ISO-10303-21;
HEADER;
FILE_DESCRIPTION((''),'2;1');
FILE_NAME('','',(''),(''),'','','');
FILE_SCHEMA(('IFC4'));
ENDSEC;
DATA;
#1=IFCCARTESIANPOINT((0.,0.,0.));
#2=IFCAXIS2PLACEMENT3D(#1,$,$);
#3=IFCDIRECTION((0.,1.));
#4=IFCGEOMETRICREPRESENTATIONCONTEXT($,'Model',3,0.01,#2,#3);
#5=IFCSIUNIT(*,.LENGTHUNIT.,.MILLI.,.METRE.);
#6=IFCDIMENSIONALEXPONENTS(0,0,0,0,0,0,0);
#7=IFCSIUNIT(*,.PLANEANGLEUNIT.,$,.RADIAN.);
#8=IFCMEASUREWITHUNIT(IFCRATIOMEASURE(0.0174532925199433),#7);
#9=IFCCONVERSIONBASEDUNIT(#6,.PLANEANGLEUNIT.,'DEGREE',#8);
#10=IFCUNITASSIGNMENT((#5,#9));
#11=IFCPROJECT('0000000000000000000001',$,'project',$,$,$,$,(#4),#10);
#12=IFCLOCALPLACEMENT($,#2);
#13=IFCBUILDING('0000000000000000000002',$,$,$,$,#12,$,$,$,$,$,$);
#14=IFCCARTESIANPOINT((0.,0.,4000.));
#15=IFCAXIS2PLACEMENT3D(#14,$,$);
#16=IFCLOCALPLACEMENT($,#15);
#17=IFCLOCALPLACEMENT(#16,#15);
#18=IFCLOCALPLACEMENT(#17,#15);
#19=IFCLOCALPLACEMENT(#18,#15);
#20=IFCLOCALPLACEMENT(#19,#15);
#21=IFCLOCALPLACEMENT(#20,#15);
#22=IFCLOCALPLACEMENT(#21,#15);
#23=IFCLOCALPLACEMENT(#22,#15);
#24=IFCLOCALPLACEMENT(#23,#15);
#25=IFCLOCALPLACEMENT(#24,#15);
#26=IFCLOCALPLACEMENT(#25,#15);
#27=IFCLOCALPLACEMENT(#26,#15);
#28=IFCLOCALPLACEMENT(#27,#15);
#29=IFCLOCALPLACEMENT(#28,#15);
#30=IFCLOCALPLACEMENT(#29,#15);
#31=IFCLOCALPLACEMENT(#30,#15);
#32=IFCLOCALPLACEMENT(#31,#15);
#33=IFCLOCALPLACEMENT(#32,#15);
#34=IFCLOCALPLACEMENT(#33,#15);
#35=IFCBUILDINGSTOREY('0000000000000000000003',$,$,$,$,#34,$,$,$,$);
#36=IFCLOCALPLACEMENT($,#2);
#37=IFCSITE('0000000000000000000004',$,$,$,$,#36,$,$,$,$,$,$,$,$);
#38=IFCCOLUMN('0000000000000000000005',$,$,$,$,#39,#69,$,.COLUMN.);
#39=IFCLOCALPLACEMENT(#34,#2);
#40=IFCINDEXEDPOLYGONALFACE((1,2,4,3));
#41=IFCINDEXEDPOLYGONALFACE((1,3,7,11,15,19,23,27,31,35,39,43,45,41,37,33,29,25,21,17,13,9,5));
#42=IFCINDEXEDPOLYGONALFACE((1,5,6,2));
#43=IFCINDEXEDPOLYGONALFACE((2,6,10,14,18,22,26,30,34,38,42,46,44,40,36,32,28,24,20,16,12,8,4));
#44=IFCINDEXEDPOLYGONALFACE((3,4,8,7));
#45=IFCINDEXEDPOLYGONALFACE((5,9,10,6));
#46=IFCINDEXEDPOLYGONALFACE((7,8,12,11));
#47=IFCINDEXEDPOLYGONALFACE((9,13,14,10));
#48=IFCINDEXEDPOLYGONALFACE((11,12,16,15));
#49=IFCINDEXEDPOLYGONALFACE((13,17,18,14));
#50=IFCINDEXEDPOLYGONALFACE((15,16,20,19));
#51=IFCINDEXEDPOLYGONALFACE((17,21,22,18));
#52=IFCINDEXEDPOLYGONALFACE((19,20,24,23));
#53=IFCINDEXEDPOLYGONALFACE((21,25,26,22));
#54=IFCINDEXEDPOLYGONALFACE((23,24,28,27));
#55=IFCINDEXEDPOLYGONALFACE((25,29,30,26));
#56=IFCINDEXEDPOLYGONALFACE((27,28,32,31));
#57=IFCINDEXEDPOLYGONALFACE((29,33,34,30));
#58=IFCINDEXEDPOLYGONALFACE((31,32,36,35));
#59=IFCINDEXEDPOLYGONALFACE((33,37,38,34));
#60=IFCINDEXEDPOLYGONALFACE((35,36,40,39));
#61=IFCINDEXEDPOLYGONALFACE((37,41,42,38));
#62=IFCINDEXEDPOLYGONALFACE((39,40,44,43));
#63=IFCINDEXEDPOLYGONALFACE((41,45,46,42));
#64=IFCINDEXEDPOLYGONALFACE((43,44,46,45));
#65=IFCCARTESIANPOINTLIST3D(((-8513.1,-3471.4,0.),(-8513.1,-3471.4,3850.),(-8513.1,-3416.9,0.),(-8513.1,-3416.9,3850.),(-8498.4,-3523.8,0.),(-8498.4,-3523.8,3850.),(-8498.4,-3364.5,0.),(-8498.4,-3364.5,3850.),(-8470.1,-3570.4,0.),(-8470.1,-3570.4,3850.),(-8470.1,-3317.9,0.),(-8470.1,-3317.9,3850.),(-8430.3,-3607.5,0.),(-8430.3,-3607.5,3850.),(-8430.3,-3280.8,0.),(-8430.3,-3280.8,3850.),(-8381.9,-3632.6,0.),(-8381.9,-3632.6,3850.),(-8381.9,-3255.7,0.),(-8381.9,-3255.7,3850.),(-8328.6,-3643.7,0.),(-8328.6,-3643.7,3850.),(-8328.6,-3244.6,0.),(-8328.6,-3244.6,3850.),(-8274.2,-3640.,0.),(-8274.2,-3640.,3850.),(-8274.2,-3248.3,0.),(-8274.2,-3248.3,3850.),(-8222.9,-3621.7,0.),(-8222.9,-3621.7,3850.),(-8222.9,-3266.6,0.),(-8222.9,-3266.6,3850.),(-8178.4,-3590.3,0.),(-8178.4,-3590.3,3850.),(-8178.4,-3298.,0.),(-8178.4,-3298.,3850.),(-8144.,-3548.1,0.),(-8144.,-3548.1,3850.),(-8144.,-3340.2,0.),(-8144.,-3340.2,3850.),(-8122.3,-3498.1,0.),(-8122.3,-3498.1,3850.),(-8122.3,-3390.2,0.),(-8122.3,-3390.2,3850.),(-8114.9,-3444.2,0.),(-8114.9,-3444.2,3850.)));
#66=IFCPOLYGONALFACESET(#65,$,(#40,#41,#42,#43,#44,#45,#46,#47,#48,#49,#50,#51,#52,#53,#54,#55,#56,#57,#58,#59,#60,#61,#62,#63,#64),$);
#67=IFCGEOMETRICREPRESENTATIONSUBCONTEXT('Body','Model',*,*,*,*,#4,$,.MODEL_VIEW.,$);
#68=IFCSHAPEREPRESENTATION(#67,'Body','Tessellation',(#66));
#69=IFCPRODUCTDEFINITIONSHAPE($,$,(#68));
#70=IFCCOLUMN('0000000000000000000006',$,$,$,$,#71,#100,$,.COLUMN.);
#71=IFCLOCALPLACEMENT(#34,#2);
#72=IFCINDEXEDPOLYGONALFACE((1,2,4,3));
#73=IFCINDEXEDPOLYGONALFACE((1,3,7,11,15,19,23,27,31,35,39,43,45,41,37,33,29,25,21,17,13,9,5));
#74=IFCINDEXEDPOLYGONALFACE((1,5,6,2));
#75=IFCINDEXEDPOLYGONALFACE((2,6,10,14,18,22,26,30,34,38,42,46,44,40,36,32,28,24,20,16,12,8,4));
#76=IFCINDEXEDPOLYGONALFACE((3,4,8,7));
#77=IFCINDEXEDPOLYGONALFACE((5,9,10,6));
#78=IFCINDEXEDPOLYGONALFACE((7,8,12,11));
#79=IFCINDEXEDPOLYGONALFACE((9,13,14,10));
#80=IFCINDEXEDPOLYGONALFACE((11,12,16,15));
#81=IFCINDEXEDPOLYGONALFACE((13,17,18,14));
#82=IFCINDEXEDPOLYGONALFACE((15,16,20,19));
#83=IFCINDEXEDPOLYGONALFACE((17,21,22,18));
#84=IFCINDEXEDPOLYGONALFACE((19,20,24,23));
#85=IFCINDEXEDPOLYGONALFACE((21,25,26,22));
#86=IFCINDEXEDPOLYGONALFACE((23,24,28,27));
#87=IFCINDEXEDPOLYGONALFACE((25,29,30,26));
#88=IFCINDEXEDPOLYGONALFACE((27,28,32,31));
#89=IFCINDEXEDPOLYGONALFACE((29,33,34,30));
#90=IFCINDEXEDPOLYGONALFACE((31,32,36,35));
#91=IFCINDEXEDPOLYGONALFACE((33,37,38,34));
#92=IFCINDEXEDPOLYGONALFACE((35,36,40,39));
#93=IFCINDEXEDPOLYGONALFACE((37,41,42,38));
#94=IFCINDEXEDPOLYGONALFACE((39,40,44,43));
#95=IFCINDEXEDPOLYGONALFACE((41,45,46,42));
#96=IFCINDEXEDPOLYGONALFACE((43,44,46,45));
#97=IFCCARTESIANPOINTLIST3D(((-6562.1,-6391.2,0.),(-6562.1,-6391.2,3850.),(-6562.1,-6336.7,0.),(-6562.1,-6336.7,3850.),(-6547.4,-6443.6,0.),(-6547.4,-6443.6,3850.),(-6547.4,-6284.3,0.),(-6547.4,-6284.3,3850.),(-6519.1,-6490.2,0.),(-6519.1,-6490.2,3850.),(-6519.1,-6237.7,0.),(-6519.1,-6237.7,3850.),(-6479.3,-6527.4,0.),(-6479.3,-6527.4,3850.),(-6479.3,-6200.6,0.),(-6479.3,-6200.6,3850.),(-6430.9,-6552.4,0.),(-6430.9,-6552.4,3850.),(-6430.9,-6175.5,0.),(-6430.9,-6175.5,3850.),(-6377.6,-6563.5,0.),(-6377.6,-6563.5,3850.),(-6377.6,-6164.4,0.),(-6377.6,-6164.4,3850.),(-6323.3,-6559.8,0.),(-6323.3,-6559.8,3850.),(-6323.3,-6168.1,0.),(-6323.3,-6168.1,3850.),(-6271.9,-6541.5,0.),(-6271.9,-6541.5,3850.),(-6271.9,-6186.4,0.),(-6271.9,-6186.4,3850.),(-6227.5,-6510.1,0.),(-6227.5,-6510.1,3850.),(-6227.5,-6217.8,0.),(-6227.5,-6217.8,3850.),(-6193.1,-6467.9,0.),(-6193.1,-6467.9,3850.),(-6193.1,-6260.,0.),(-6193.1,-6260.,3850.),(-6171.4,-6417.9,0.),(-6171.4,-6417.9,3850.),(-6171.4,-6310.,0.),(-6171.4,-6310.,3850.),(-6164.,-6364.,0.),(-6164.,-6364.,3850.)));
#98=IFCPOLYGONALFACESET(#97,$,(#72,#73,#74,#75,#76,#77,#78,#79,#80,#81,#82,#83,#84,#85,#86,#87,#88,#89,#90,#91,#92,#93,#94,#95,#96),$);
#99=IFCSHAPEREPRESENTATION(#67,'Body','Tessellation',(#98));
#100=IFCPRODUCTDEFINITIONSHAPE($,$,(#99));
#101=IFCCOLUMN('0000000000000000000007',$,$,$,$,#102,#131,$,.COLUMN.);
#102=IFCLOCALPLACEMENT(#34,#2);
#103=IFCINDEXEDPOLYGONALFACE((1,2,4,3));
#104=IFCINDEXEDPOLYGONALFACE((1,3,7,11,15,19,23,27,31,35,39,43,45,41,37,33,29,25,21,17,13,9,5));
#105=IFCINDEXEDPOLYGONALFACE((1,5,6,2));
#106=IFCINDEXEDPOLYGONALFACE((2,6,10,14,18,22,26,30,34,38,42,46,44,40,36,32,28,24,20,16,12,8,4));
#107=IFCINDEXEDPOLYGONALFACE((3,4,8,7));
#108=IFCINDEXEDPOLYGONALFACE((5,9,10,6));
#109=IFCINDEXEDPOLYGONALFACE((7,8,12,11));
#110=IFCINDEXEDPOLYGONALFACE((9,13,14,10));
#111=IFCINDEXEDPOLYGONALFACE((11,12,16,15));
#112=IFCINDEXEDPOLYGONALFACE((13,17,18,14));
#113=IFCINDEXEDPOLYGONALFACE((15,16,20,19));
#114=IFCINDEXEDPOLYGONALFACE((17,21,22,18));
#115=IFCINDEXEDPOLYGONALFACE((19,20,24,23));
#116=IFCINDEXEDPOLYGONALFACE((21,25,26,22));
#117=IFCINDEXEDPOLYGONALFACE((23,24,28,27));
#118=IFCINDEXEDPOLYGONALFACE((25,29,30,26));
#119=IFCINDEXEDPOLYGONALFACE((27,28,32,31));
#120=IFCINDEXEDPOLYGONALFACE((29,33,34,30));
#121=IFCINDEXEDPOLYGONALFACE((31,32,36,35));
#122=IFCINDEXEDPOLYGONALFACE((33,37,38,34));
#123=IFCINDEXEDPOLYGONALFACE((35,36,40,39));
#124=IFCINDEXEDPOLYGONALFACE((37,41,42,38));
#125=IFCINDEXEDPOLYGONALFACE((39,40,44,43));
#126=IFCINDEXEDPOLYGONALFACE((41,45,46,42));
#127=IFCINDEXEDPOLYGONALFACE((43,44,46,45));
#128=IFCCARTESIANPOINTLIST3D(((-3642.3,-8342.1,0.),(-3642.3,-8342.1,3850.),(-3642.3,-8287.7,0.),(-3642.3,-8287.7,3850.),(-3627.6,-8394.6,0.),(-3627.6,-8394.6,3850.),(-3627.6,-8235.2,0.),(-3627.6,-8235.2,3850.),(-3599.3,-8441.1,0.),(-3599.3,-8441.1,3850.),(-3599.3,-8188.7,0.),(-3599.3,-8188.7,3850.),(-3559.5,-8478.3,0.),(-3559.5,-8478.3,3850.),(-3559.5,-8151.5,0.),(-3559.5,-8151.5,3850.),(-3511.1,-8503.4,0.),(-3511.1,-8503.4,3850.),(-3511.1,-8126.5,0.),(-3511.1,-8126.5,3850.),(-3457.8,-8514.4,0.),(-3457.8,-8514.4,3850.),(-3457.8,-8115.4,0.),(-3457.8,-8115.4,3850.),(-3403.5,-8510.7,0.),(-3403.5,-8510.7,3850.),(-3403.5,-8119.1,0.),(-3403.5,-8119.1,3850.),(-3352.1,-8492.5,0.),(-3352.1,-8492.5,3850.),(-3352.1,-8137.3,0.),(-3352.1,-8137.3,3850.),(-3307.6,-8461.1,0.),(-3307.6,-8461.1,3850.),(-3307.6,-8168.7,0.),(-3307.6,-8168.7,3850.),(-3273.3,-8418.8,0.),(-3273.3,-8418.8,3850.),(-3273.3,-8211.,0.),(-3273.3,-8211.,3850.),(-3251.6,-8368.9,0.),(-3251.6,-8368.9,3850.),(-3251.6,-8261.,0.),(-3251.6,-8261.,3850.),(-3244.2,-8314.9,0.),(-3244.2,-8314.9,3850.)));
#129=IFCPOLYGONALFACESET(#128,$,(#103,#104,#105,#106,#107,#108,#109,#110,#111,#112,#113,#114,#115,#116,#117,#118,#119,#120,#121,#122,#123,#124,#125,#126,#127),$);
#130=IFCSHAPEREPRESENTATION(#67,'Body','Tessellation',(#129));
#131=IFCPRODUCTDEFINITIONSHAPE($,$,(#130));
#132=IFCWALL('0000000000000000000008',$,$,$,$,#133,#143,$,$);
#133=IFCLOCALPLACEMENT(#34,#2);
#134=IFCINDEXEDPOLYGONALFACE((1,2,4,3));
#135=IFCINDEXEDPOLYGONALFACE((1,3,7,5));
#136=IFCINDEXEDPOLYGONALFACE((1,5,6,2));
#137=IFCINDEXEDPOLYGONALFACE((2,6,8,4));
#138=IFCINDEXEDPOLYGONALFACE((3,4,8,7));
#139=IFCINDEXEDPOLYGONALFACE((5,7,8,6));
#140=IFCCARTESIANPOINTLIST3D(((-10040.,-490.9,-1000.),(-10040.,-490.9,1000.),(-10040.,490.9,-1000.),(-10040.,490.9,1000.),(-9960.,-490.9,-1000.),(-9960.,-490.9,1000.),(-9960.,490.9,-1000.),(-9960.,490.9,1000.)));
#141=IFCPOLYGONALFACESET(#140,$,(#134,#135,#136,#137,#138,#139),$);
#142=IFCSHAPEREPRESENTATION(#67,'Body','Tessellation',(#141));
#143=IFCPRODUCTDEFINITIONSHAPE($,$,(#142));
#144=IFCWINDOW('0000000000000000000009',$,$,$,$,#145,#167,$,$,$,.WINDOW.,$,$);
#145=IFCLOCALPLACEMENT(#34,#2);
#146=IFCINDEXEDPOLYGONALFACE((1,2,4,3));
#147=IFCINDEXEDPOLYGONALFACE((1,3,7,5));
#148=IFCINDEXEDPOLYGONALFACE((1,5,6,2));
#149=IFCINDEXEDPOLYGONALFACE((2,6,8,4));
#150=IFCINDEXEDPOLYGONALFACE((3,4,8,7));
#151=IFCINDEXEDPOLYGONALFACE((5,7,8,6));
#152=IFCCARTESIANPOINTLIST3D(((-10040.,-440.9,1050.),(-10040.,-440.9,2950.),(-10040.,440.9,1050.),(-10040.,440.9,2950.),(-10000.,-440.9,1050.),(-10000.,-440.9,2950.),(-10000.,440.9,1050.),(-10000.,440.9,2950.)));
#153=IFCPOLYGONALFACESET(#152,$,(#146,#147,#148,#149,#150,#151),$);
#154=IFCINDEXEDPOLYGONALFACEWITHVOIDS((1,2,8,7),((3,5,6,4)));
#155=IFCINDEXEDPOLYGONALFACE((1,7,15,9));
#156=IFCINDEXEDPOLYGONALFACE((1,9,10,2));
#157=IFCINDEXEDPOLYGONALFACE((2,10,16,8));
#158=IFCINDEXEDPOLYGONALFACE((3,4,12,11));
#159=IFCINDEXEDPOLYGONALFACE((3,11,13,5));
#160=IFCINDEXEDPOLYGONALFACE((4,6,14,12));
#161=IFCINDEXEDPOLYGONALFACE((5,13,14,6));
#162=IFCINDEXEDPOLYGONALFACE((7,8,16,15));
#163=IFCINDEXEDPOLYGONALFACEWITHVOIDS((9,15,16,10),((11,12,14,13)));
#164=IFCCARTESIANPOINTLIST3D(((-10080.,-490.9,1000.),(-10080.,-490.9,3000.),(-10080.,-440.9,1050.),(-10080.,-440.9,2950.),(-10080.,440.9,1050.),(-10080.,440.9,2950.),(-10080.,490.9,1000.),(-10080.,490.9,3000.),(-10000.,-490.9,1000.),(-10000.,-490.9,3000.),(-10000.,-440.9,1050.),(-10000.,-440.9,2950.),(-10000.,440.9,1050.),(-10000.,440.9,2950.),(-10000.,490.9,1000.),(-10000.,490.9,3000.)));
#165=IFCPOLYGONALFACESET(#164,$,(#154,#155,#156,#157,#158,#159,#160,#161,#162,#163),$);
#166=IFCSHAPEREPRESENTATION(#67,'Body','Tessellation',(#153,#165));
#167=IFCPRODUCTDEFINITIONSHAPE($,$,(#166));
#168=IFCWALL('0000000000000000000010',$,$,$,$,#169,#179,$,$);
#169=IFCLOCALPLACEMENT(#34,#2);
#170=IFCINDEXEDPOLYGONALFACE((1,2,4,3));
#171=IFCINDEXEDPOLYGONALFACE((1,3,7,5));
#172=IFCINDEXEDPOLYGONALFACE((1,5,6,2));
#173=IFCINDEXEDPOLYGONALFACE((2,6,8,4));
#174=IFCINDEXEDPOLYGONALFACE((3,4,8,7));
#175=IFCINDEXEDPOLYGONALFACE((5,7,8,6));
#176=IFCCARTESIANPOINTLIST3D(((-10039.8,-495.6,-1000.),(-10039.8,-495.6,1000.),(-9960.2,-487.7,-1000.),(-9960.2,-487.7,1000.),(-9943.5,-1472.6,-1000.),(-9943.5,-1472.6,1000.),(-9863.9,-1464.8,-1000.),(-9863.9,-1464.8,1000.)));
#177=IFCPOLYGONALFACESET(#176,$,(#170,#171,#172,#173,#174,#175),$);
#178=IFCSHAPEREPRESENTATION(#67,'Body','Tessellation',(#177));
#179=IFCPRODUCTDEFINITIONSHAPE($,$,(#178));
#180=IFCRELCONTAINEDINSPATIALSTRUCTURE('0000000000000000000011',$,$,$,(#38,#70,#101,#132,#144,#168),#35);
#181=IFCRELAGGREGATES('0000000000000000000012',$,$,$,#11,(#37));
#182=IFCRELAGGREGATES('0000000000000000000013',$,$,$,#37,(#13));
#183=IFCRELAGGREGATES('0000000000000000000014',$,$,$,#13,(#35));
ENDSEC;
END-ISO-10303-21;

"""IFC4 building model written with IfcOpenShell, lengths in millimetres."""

from ifc_helpers import new_model, entity, si_unit, converted_unit, direction, frame, origin, origin_2d, place, context, subcontext, project, spatial, rectangle, circle, extrude, element, save


model = new_model("IFC4")

# Units and contexts
model_context = context("Model", 3, precision=0.01, world=origin(), true_north=direction((0.0, 1.0)))
body_context = subcontext(model_context, "Body", "Model", "MODEL_VIEW")
ifc_project = project(units=[si_unit("LENGTHUNIT", "METRE", prefix="MILLI"), converted_unit("PLANEANGLEUNIT", "DEGREE", entity("IfcRatioMeasure", 0.0174532925199433), si_unit("PLANEANGLEUNIT", "RADIAN"), dimensions=[0, 0, 0, 0, 0, 0, 0])], contexts=[model_context])

# Site, building, storey
site_placement = place(None, origin())
site = spatial("IfcSite", under=ifc_project, at=site_placement)
building_placement = place(None, origin())
building = spatial("IfcBuilding", under=site, at=building_placement)
placement_1 = place(None, frame((0.0, 0.0, 4000.0)))
placement_2 = place(placement_1, frame((0.0, 0.0, 4000.0)))
placement_3 = place(placement_2, frame((0.0, 0.0, 4000.0)))
placement_4 = place(placement_3, frame((0.0, 0.0, 4000.0)))
placement_5 = place(placement_4, frame((0.0, 0.0, 4000.0)))
placement_6 = place(placement_5, frame((0.0, 0.0, 4000.0)))
placement_7 = place(placement_6, frame((0.0, 0.0, 4000.0)))
placement_8 = place(placement_7, frame((0.0, 0.0, 4000.0)))
placement_9 = place(placement_8, frame((0.0, 0.0, 4000.0)))
placement_10 = place(placement_9, frame((0.0, 0.0, 4000.0)))
placement_11 = place(placement_10, frame((0.0, 0.0, 4000.0)))
placement_12 = place(placement_11, frame((0.0, 0.0, 4000.0)))
placement_13 = place(placement_12, frame((0.0, 0.0, 4000.0)))
placement_14 = place(placement_13, frame((0.0, 0.0, 4000.0)))
placement_15 = place(placement_14, frame((0.0, 0.0, 4000.0)))
placement_16 = place(placement_15, frame((0.0, 0.0, 4000.0)))
placement_17 = place(placement_16, frame((0.0, 0.0, 4000.0)))
placement_18 = place(placement_17, frame((0.0, 0.0, 4000.0)))
storey_placement = place(placement_18, frame((0.0, 0.0, 4000.0)))
storey = spatial("IfcBuildingStorey", under=building, at=storey_placement)

# Columns
for number, where in (
    (1, (-8314.9, -3444.2, 0.0)),
    (2, (-6364.0, -6364.0, 0.0)),
    (3, (-3444.2, -8314.9, 0.0)),
):
    element("IfcColumn", number, at=place(storey_placement, frame(where)), inside=storey, PredefinedType="COLUMN", context=body_context, shape_type="SweptSolid", body=[
        extrude(circle(Radius=200.0, at=origin_2d()), origin(), (0.0, 0.0, 1.0), 3850.0),
    ])

# Wall
wall_1_placement = place(storey_placement, frame((-10000.0, 0.0, -1000.0), z_axis=(0.0, 0.0, 1.0), x_axis=(0.000874, -10000.0, 0.0)))
element("IfcWall", 4, at=wall_1_placement, inside=storey, context=body_context, shape_type="SweptSolid", body=[
    extrude(rectangle(XDim=981.7, YDim=80.0, at=origin_2d()), origin(), (0.0, 0.0, 1.0), 2000.0),
])

# Window
cartesian_point_1 = entity("IfcCartesianPoint", [-440.9, -950.0])
shared_polyline = entity("IfcPolyline", [cartesian_point_1, entity("IfcCartesianPoint", [-440.9, 950.0]), entity("IfcCartesianPoint", [-440.9, 950.0]), entity("IfcCartesianPoint", [440.9, 950.0]), entity("IfcCartesianPoint", [440.9, 950.0]), entity("IfcCartesianPoint", [440.9, -950.0]), entity("IfcCartesianPoint", [440.9, -950.0]), entity("IfcCartesianPoint", [-440.9, -950.0]), cartesian_point_1])
window_1_placement = place(storey_placement, frame((-10000.0, 0.0, 2000.0), z_axis=(0.0, 0.0, 1.0), x_axis=(0.000874, -10000.0, 0.0)))
cartesian_point_2 = entity("IfcCartesianPoint", [-490.9, -1000.0])
element("IfcWindow", 5, at=window_1_placement, inside=storey, PredefinedType="WINDOW", context=body_context, shape_type="SweptSolid", body=[
    entity("IfcExtrudedAreaSolid", entity("IfcArbitraryClosedProfileDef", "AREA", None, shared_polyline), entity("IfcAxis2Placement3D", entity("IfcCartesianPoint", [0.0, 0.0, 0.0]), entity("IfcDirection", [0.0, -1.0, 0.0]), entity("IfcDirection", [1.0, 0.0, 0.0])), entity("IfcDirection", [0.0, 0.0, 1.0]), 40.0),
    entity("IfcExtrudedAreaSolid", entity("IfcArbitraryProfileDefWithVoids", "AREA", None, entity("IfcPolyline", [cartesian_point_2, entity("IfcCartesianPoint", [-490.9, 1000.0]), entity("IfcCartesianPoint", [-490.9, 1000.0]), entity("IfcCartesianPoint", [490.9, 1000.0]), entity("IfcCartesianPoint", [490.9, 1000.0]), entity("IfcCartesianPoint", [490.9, -1000.0]), entity("IfcCartesianPoint", [490.9, -1000.0]), entity("IfcCartesianPoint", [-490.9, -1000.0]), cartesian_point_2]), [shared_polyline]), entity("IfcAxis2Placement3D", entity("IfcCartesianPoint", [0.0, 0.0, 0.0]), entity("IfcDirection", [0.0, -1.0, 0.0]), entity("IfcDirection", [1.0, 0.0, 0.0])), entity("IfcDirection", [0.0, 0.0, 1.0]), 80.0),
])

# Wall
wall_2_placement = place(storey_placement, frame((-9951.8, -980.2, -1000.0), z_axis=(0.0, 0.0, 1.0), x_axis=(980.170299, -9951.847376, 0.0)))
element("IfcWall", 6, at=wall_2_placement, inside=storey, context=body_context, shape_type="SweptSolid", body=[
    extrude(rectangle(XDim=981.7, YDim=80.0, at=origin_2d()), origin(), (0.0, 0.0, 1.0), 2000.0),
])

save(model, "model.ifc")
